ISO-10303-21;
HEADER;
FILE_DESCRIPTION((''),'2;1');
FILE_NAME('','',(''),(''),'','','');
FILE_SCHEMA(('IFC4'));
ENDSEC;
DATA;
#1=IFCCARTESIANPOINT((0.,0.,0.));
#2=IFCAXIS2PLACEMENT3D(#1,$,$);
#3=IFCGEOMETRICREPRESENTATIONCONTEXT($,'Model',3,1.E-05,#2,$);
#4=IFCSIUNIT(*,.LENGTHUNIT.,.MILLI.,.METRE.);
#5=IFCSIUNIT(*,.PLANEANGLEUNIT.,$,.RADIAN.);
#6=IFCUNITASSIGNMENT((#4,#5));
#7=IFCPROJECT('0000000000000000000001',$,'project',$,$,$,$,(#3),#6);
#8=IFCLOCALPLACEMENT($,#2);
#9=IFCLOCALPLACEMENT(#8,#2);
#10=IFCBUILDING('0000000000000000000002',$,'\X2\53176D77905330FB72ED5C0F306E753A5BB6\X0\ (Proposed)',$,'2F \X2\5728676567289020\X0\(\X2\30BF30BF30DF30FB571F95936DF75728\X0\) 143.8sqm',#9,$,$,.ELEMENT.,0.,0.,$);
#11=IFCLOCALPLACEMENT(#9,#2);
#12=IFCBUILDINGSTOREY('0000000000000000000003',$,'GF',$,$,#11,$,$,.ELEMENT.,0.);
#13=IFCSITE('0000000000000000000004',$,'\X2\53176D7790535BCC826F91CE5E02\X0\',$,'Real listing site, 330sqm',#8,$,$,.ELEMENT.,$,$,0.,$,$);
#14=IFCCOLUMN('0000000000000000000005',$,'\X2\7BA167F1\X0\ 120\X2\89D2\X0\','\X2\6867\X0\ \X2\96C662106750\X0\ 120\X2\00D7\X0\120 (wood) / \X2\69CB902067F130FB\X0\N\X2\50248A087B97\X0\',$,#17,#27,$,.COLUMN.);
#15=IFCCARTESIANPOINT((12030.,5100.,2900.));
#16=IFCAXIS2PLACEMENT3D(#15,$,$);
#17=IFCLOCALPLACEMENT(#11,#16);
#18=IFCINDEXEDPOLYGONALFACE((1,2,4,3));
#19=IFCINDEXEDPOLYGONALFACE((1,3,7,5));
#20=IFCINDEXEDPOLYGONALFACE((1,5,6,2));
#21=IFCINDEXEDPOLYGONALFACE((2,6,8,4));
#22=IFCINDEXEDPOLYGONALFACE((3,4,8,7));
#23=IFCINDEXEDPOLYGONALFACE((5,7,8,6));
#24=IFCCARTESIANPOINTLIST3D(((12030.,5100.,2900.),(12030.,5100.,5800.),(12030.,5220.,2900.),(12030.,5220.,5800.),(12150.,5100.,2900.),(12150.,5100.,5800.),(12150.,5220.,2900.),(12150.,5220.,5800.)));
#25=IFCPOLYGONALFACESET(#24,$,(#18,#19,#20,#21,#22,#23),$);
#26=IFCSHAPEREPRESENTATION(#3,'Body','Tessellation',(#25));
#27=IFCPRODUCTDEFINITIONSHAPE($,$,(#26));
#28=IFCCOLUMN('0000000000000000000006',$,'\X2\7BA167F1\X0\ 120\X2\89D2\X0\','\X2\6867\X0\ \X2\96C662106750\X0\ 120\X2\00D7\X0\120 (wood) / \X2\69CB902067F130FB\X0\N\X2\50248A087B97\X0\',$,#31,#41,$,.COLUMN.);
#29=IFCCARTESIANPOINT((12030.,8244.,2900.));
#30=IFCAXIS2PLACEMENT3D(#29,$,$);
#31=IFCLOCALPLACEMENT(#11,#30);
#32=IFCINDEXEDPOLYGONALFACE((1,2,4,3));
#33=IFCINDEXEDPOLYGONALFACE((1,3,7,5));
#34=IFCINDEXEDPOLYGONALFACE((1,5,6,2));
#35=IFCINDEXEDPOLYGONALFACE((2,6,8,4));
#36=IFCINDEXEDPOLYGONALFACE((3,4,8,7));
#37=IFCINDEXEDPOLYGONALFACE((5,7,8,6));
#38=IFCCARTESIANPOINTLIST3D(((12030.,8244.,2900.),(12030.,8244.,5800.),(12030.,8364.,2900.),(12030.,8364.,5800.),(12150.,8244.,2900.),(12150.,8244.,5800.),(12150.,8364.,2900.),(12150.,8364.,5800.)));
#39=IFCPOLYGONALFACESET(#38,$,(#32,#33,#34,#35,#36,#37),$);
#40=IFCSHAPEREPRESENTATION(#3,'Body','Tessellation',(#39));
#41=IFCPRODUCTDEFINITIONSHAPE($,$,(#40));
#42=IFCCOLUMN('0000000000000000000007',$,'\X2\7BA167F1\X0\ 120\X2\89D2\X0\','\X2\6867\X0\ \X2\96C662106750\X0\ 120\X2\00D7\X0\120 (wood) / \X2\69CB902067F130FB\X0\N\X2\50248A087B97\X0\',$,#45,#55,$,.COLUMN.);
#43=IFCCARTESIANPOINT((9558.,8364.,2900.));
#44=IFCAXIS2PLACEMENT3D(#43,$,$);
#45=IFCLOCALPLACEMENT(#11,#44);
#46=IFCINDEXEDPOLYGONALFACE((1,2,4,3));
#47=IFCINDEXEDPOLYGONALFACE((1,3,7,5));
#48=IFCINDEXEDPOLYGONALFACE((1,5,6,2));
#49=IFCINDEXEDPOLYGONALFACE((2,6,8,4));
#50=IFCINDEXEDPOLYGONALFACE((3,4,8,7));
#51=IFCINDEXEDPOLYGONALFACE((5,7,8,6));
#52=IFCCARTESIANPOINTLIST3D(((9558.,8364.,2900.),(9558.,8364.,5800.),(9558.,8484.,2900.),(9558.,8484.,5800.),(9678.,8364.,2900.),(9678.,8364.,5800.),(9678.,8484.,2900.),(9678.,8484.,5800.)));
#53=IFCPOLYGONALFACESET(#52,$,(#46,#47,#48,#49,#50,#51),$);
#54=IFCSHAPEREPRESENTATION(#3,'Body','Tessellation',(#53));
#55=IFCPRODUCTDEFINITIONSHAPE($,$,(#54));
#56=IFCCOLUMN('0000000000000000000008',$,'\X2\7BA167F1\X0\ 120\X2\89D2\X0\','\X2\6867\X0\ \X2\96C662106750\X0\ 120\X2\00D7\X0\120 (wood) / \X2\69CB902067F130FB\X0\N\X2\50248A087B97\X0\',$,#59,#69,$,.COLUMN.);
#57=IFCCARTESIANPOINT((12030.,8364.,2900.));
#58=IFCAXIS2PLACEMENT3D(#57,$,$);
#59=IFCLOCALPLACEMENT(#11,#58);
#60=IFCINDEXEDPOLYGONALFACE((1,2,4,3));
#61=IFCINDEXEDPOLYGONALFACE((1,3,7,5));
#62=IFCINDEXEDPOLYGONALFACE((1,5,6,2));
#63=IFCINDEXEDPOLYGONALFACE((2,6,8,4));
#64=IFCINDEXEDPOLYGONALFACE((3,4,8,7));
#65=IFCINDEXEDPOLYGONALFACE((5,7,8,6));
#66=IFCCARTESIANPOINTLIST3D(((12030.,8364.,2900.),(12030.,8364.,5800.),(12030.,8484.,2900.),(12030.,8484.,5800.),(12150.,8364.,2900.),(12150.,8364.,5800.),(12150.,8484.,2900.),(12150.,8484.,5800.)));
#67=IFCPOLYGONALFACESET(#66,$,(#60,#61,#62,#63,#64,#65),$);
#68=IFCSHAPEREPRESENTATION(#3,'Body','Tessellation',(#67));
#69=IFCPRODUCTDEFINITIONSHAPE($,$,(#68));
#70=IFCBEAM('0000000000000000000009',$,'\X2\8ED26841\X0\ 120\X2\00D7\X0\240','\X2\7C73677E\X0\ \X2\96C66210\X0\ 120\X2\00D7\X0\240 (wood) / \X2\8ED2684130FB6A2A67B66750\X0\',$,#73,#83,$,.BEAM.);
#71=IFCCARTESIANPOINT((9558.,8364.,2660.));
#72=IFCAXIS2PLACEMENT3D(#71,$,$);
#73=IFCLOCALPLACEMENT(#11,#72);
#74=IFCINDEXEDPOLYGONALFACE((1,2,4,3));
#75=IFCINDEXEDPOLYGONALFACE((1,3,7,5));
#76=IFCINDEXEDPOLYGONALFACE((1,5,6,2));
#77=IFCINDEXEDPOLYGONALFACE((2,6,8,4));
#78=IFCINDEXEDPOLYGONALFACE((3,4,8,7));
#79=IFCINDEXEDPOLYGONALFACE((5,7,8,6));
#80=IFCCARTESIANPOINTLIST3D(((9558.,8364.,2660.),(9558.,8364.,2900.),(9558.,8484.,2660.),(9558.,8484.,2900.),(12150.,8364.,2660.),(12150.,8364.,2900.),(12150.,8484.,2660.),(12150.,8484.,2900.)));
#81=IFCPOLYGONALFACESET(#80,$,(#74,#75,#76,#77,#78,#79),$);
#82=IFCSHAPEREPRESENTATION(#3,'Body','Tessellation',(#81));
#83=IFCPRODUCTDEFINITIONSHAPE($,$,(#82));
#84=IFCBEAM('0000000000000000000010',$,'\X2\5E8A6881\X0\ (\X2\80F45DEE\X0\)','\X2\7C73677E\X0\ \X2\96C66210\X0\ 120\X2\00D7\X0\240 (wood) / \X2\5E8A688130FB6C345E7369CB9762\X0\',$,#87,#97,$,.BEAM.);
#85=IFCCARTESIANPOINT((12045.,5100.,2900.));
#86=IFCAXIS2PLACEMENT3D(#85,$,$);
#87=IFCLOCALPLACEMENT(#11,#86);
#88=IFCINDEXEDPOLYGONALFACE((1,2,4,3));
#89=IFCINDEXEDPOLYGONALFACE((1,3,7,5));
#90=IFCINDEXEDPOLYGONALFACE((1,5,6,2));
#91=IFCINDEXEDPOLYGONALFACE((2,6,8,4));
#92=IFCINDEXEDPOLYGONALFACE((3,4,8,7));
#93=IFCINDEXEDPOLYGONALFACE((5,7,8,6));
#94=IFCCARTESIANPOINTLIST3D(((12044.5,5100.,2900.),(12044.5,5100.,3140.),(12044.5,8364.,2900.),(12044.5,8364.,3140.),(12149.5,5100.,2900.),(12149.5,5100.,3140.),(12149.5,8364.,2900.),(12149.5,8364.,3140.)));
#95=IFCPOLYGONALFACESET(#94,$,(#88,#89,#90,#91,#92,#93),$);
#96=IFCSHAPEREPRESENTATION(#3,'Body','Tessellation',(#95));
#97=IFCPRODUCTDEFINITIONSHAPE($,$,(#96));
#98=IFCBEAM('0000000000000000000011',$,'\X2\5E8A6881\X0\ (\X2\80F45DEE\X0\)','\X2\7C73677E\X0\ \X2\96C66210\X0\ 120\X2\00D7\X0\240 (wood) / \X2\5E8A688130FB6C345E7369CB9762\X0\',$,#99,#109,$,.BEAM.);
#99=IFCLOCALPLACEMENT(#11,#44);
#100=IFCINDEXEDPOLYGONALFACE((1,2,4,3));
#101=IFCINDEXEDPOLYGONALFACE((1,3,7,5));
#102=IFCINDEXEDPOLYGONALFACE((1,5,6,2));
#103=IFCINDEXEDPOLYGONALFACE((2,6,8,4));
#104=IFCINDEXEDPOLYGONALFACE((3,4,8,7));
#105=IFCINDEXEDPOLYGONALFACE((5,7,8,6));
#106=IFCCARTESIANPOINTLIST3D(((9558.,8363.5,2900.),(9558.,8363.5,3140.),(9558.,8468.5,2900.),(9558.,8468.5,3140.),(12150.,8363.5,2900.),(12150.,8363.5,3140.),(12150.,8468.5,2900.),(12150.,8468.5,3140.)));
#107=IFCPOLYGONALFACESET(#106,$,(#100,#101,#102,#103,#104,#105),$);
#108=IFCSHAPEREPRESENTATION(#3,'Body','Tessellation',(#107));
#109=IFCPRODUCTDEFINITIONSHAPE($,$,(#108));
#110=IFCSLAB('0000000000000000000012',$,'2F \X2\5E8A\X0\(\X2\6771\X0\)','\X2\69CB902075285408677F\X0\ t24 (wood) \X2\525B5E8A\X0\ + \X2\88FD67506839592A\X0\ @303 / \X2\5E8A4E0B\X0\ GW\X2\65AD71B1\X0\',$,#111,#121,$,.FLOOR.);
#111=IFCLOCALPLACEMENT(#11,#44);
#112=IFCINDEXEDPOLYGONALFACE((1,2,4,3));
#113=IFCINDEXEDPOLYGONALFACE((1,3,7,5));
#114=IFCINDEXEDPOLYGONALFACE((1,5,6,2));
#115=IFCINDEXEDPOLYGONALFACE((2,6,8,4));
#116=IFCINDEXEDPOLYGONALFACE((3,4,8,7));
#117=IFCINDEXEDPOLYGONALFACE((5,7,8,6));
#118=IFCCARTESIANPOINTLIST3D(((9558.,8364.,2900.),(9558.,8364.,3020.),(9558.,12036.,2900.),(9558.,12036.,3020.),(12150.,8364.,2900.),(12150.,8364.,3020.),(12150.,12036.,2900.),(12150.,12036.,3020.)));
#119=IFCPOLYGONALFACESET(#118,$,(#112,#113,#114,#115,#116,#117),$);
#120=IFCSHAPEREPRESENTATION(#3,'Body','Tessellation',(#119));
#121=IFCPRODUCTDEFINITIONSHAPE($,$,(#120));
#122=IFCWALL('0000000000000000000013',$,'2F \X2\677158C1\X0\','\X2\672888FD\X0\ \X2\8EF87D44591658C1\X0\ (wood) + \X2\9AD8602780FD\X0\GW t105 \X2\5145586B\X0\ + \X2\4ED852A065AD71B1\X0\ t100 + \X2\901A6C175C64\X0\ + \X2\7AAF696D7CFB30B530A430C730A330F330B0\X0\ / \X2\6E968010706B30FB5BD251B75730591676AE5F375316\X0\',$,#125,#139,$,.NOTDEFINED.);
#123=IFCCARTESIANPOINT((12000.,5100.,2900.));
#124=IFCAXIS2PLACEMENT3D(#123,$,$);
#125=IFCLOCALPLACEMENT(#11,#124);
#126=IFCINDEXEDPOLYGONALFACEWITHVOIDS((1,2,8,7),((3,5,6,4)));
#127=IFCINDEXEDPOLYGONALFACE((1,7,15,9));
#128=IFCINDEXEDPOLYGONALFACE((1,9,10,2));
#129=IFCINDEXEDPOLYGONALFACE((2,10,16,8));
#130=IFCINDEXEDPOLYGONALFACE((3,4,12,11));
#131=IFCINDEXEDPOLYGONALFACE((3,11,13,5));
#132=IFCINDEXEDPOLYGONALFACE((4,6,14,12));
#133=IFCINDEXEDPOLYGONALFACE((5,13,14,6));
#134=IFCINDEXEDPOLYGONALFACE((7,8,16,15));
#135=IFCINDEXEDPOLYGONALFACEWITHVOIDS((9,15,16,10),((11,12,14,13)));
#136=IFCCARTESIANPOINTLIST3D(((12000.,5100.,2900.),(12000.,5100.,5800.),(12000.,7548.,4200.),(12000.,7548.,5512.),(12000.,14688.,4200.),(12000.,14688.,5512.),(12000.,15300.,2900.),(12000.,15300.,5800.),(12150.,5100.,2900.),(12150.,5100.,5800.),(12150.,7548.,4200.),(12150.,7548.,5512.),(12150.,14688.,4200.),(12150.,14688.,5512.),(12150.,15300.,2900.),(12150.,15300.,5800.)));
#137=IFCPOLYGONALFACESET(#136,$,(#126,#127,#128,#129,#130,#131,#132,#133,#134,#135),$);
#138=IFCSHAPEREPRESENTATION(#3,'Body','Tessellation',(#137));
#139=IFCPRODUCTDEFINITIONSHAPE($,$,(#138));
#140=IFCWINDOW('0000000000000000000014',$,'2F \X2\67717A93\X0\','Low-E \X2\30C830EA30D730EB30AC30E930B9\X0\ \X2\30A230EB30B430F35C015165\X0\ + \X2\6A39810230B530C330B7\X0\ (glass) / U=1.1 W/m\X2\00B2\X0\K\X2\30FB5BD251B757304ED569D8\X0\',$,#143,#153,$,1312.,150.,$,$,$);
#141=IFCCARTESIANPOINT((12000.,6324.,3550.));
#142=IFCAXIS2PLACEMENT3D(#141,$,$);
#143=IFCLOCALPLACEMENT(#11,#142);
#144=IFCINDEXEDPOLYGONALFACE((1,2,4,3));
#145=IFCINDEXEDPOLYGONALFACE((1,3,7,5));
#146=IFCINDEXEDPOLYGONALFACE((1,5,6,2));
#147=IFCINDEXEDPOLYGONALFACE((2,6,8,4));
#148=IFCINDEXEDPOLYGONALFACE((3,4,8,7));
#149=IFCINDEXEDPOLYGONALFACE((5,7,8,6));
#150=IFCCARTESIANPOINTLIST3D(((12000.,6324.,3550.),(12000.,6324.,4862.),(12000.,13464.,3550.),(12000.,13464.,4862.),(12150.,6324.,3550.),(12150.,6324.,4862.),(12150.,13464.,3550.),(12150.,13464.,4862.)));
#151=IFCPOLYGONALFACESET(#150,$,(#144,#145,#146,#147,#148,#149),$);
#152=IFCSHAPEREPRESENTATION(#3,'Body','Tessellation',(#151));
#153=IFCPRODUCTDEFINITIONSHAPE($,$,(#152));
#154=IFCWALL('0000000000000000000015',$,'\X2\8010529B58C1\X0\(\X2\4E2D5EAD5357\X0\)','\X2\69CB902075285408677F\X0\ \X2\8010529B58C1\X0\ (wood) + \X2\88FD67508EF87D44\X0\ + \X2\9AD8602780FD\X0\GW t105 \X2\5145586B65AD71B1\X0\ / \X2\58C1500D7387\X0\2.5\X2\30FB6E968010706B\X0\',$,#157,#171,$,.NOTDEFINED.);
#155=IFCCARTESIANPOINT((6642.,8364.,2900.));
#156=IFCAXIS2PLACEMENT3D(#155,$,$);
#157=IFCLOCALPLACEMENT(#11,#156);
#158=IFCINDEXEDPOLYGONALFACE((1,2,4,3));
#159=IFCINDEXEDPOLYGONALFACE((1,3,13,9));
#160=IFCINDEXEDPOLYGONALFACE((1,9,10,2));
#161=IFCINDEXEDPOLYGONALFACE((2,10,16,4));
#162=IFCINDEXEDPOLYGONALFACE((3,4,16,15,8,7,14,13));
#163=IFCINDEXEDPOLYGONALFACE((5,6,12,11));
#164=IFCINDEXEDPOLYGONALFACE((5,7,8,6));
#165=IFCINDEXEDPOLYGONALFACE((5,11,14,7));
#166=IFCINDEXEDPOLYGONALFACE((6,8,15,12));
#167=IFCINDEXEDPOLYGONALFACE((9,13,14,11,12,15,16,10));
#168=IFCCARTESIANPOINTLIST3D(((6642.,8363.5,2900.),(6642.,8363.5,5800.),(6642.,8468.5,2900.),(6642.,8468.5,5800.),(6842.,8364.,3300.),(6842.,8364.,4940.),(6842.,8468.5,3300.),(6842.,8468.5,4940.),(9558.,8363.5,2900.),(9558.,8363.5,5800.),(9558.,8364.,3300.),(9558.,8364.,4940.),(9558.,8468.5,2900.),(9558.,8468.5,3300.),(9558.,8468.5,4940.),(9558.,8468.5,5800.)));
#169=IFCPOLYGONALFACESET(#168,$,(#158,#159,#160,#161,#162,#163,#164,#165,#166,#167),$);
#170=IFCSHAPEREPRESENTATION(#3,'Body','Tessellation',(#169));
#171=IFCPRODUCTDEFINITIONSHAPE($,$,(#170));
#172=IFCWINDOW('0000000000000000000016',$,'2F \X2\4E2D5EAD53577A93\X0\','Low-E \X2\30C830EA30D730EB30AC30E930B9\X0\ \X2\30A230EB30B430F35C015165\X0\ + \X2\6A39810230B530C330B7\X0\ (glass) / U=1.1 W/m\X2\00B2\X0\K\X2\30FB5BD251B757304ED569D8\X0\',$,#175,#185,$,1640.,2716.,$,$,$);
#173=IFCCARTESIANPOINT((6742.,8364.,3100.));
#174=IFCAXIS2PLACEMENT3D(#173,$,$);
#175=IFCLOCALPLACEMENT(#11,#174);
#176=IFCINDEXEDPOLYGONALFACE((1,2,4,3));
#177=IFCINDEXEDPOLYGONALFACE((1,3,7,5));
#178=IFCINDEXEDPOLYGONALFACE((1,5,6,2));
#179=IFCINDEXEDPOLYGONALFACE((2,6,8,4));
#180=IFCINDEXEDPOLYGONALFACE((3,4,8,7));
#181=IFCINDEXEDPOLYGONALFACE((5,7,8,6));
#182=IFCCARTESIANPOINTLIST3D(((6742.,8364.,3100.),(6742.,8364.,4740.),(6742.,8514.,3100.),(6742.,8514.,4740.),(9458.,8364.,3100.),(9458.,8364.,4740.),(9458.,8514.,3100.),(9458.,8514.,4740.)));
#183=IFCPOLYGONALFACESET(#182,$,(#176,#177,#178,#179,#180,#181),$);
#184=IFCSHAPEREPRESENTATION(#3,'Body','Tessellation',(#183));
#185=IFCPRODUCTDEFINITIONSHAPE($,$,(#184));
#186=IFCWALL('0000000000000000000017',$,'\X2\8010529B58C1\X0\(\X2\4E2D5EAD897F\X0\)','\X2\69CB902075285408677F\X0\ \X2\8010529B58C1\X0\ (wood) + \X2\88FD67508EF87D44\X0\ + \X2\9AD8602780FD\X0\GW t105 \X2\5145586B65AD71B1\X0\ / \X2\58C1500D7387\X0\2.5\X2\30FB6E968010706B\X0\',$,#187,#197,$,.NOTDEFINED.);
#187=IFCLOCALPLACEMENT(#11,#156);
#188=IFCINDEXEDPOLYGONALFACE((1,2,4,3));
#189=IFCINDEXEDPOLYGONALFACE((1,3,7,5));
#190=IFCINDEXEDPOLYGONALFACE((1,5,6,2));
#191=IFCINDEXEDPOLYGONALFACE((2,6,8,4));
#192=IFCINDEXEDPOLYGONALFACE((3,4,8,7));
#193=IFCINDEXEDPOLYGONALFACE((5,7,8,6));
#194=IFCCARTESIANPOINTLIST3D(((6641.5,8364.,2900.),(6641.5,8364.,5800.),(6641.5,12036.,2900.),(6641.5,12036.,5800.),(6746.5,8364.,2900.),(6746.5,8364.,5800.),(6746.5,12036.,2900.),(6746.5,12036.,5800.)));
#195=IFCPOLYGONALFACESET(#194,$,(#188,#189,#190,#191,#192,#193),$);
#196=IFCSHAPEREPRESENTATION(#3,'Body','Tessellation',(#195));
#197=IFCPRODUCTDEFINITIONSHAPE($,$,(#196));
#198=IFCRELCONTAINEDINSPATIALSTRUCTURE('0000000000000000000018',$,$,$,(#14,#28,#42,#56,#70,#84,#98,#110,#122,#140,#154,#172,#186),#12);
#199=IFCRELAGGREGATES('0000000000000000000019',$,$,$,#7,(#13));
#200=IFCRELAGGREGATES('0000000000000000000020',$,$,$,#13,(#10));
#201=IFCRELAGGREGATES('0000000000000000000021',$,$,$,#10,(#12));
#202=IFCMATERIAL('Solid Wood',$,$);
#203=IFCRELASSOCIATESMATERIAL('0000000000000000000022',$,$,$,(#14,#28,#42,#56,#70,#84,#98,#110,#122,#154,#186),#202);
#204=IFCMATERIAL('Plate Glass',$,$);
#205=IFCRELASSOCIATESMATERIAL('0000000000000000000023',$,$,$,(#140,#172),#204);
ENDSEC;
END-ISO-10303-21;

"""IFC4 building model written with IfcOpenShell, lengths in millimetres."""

from ifc_helpers import new_model, si_unit, frame, frame_2d, origin, place, context, project, spatial, rectangle, extrude, material, element, fill, save


model = new_model("IFC4")

# Units and contexts
model_context = context("Model", 3, precision=1e-05, world=origin())
ifc_project = project(units=[si_unit("LENGTHUNIT", "METRE", prefix="MILLI"), si_unit("PLANEANGLEUNIT", "RADIAN")], contexts=[model_context])

# Site, building, storey
site_placement = place(None, origin())
site = spatial("IfcSite", under=ifc_project, at=site_placement, Name="北海道富良野市", ObjectType="Real listing site, 330sqm", CompositionType="ELEMENT", RefElevation=0.0)
building_placement = place(site_placement, origin())
building = spatial("IfcBuilding", under=site, at=building_placement, Name="北海道・狭小の町家 (Proposed)", ObjectType="2F 在来木造(タタミ・土間混在) 143.8sqm", CompositionType="ELEMENT", ElevationOfRefHeight=0.0, ElevationOfTerrain=0.0)
storey_placement = place(building_placement, origin())
storey = spatial("IfcBuildingStorey", under=building, at=storey_placement, Name="GF", CompositionType="ELEMENT", Elevation=0.0)

# Columns
ifc_material_1 = material(Name="Solid Wood")
column_1_placement = place(storey_placement, frame((12030.0, 5100.0, 2900.0)))
element("IfcColumn", 1, at=column_1_placement, inside=storey, material=ifc_material_1, Name="管柱 120角", Description="桧 集成材 120×120 (wood) / 構造柱・N値計算", PredefinedType="COLUMN", context=model_context, shape_type="SweptSolid", body=[
    extrude(rectangle(XDim=120.0, YDim=120.0, at=frame_2d((60.0, 60.0))), frame((12030.0, 5100.0, 2900.0)), (0.0, 0.0, 1.0), 2900.0),
])
column_2_placement = place(storey_placement, frame((12030.0, 8244.0, 2900.0)))
element("IfcColumn", 2, at=column_2_placement, inside=storey, material=ifc_material_1, Name="管柱 120角", Description="桧 集成材 120×120 (wood) / 構造柱・N値計算", PredefinedType="COLUMN", context=model_context, shape_type="SweptSolid", body=[
    extrude(rectangle(XDim=120.0, YDim=120.0, at=frame_2d((60.0, 60.0))), frame((12030.0, 8244.0, 2900.0)), (0.0, 0.0, 1.0), 2900.0),
])
column_3_placement = place(storey_placement, frame((9558.0, 8364.0, 2900.0)))
element("IfcColumn", 3, at=column_3_placement, inside=storey, material=ifc_material_1, Name="管柱 120角", Description="桧 集成材 120×120 (wood) / 構造柱・N値計算", PredefinedType="COLUMN", context=model_context, shape_type="SweptSolid", body=[
    extrude(rectangle(XDim=120.0, YDim=120.0, at=frame_2d((60.0, 60.0))), frame((9558.0, 8364.0, 2900.0)), (0.0, 0.0, 1.0), 2900.0),
])
column_4_placement = place(storey_placement, frame((12030.0, 8364.0, 2900.0)))
element("IfcColumn", 4, at=column_4_placement, inside=storey, material=ifc_material_1, Name="管柱 120角", Description="桧 集成材 120×120 (wood) / 構造柱・N値計算", PredefinedType="COLUMN", context=model_context, shape_type="SweptSolid", body=[
    extrude(rectangle(XDim=120.0, YDim=120.0, at=frame_2d((60.0, 60.0))), frame((12030.0, 8364.0, 2900.0)), (0.0, 0.0, 1.0), 2900.0),
])

# Beams
beam_1_placement = place(storey_placement, frame((9558.0, 8364.0, 2660.0)))
element("IfcBeam", 5, at=beam_1_placement, inside=storey, material=ifc_material_1, Name="軒桁 120×240", Description="米松 集成 120×240 (wood) / 軒桁・横架材", PredefinedType="BEAM", context=model_context, shape_type="SweptSolid", body=[
    extrude(rectangle(XDim=2592.0, YDim=120.0, at=frame_2d((1296.0, 60.0))), frame((9558.0, 8364.0, 2660.0)), (0.0, 0.0, 1.0), 240.0),
])
beam_2_placement = place(storey_placement, frame((12045.0, 5100.0, 2900.0)))
element("IfcBeam", 6, at=beam_2_placement, inside=storey, material=ifc_material_1, Name="床梁 (胴差)", Description="米松 集成 120×240 (wood) / 床梁・水平構面", PredefinedType="BEAM", context=model_context, shape_type="SweptSolid", body=[
    extrude(rectangle(XDim=105.0, YDim=3264.0, at=frame_2d((52.0, 1632.0))), frame((12045.0, 5100.0, 2900.0)), (0.0, 0.0, 1.0), 240.0),
])
beam_3_placement = place(storey_placement, frame((9558.0, 8364.0, 2900.0)))
element("IfcBeam", 7, at=beam_3_placement, inside=storey, material=ifc_material_1, Name="床梁 (胴差)", Description="米松 集成 120×240 (wood) / 床梁・水平構面", PredefinedType="BEAM", context=model_context, shape_type="SweptSolid", body=[
    extrude(rectangle(XDim=2592.0, YDim=105.0, at=frame_2d((1296.0, 52.0))), frame((9558.0, 8364.0, 2900.0)), (0.0, 0.0, 1.0), 240.0),
])

# Slab
slab_placement = place(storey_placement, frame((9558.0, 8364.0, 2900.0)))
element("IfcSlab", 8, at=slab_placement, inside=storey, material=ifc_material_1, Name="2F 床(東)", Description="構造用合板 t24 (wood) 剛床 + 製材根太 @303 / 床下 GW断熱", PredefinedType="FLOOR", context=model_context, shape_type="SweptSolid", body=[
    extrude(rectangle(XDim=2592.0, YDim=3672.0, at=frame_2d((1296.0, 1836.0))), frame((9558.0, 8364.0, 2900.0)), (0.0, 0.0, 1.0), 120.0),
])

# Walls, openings, windows
wall_1_placement = place(storey_placement, frame((12000.0, 5100.0, 2900.0)))
wall_1 = element("IfcWall", 9, at=wall_1_placement, inside=storey, material=ifc_material_1, Name="2F 東壁", Description="木製 軸組外壁 (wood) + 高性能GW t105 充填 + 付加断熱 t100 + 通気層 + 窯業系サイディング / 準耐火・寒冷地外皮強化", PredefinedType="NOTDEFINED", context=model_context, shape_type="SweptSolid", body=[
    extrude(rectangle(XDim=150.0, YDim=10200.0, at=frame_2d((75.0, 5100.0))), frame((12000.0, 5100.0, 2900.0)), (0.0, 0.0, 1.0), 2900.0),
])
opening_1_placement = place(storey_placement, frame((12000.0, 6324.0, 3550.0)))
opening_1 = element("IfcOpeningElement", 10, at=opening_1_placement, cuts=wall_1, PredefinedType="NOTDEFINED", context=model_context, shape_type="SweptSolid", body=[
    extrude(rectangle(XDim=150.0, YDim=7140.0, at=frame_2d((75.0, 3570.0))), frame((12000.0, 6324.0, 3550.0)), (0.0, 0.0, 1.0), 1312.0),
])
ifc_material_2 = material(Name="Plate Glass")
window_1_placement = place(storey_placement, frame((12000.0, 6324.0, 3550.0)))
window_1 = element("IfcWindow", 11, at=window_1_placement, inside=storey, material=ifc_material_2, Name="2F 東窓", Description="Low-E トリプルガラス アルゴン封入 + 樹脂サッシ (glass) / U=1.1 W/m²K・寒冷地仕様", OverallHeight=1312.0, OverallWidth=150.0, context=model_context, shape_type="SweptSolid", body=[
    extrude(rectangle(XDim=150.0, YDim=7140.0, at=frame_2d((75.0, 3570.0))), frame((12000.0, 6324.0, 3550.0)), (0.0, 0.0, 1.0), 1312.0),
])
fill(opening_1, window_1)
wall_2_placement = place(storey_placement, frame((6642.0, 8364.0, 2900.0)))
wall_2 = element("IfcWall", 12, at=wall_2_placement, inside=storey, material=ifc_material_1, Name="耐力壁(中庭南)", Description="構造用合板 耐力壁 (wood) + 製材軸組 + 高性能GW t105 充填断熱 / 壁倍率2.5・準耐火", PredefinedType="NOTDEFINED", context=model_context, shape_type="SweptSolid", body=[
    extrude(rectangle(XDim=2916.0, YDim=105.0, at=frame_2d((1458.0, 52.0))), frame((6642.0, 8364.0, 2900.0)), (0.0, 0.0, 1.0), 2900.0),
])
opening_2_placement = place(storey_placement, frame((6742.0, 8364.0, 3100.0)))
opening_2 = element("IfcOpeningElement", 13, at=opening_2_placement, cuts=wall_2, PredefinedType="NOTDEFINED", context=model_context, shape_type="SweptSolid", body=[
    extrude(rectangle(XDim=2716.0, YDim=150.0, at=frame_2d((1358.0, 75.0))), frame((6742.0, 8364.0, 3100.0)), (0.0, 0.0, 1.0), 1640.0),
])
window_2_placement = place(storey_placement, frame((6742.0, 8364.0, 3100.0)))
window_2 = element("IfcWindow", 14, at=window_2_placement, inside=storey, material=ifc_material_2, Name="2F 中庭南窓", Description="Low-E トリプルガラス アルゴン封入 + 樹脂サッシ (glass) / U=1.1 W/m²K・寒冷地仕様", OverallHeight=1640.0, OverallWidth=2716.0, context=model_context, shape_type="SweptSolid", body=[
    extrude(rectangle(XDim=2716.0, YDim=150.0, at=frame_2d((1358.0, 75.0))), frame((6742.0, 8364.0, 3100.0)), (0.0, 0.0, 1.0), 1640.0),
])
fill(opening_2, window_2)

# Wall
wall_3_placement = place(storey_placement, frame((6642.0, 8364.0, 2900.0)))
element("IfcWall", 15, at=wall_3_placement, inside=storey, material=ifc_material_1, Name="耐力壁(中庭西)", Description="構造用合板 耐力壁 (wood) + 製材軸組 + 高性能GW t105 充填断熱 / 壁倍率2.5・準耐火", PredefinedType="NOTDEFINED", context=model_context, shape_type="SweptSolid", body=[
    extrude(rectangle(XDim=105.0, YDim=3672.0, at=frame_2d((52.0, 1836.0))), frame((6642.0, 8364.0, 2900.0)), (0.0, 0.0, 1.0), 2900.0),
])

save(model, "model.ifc")
